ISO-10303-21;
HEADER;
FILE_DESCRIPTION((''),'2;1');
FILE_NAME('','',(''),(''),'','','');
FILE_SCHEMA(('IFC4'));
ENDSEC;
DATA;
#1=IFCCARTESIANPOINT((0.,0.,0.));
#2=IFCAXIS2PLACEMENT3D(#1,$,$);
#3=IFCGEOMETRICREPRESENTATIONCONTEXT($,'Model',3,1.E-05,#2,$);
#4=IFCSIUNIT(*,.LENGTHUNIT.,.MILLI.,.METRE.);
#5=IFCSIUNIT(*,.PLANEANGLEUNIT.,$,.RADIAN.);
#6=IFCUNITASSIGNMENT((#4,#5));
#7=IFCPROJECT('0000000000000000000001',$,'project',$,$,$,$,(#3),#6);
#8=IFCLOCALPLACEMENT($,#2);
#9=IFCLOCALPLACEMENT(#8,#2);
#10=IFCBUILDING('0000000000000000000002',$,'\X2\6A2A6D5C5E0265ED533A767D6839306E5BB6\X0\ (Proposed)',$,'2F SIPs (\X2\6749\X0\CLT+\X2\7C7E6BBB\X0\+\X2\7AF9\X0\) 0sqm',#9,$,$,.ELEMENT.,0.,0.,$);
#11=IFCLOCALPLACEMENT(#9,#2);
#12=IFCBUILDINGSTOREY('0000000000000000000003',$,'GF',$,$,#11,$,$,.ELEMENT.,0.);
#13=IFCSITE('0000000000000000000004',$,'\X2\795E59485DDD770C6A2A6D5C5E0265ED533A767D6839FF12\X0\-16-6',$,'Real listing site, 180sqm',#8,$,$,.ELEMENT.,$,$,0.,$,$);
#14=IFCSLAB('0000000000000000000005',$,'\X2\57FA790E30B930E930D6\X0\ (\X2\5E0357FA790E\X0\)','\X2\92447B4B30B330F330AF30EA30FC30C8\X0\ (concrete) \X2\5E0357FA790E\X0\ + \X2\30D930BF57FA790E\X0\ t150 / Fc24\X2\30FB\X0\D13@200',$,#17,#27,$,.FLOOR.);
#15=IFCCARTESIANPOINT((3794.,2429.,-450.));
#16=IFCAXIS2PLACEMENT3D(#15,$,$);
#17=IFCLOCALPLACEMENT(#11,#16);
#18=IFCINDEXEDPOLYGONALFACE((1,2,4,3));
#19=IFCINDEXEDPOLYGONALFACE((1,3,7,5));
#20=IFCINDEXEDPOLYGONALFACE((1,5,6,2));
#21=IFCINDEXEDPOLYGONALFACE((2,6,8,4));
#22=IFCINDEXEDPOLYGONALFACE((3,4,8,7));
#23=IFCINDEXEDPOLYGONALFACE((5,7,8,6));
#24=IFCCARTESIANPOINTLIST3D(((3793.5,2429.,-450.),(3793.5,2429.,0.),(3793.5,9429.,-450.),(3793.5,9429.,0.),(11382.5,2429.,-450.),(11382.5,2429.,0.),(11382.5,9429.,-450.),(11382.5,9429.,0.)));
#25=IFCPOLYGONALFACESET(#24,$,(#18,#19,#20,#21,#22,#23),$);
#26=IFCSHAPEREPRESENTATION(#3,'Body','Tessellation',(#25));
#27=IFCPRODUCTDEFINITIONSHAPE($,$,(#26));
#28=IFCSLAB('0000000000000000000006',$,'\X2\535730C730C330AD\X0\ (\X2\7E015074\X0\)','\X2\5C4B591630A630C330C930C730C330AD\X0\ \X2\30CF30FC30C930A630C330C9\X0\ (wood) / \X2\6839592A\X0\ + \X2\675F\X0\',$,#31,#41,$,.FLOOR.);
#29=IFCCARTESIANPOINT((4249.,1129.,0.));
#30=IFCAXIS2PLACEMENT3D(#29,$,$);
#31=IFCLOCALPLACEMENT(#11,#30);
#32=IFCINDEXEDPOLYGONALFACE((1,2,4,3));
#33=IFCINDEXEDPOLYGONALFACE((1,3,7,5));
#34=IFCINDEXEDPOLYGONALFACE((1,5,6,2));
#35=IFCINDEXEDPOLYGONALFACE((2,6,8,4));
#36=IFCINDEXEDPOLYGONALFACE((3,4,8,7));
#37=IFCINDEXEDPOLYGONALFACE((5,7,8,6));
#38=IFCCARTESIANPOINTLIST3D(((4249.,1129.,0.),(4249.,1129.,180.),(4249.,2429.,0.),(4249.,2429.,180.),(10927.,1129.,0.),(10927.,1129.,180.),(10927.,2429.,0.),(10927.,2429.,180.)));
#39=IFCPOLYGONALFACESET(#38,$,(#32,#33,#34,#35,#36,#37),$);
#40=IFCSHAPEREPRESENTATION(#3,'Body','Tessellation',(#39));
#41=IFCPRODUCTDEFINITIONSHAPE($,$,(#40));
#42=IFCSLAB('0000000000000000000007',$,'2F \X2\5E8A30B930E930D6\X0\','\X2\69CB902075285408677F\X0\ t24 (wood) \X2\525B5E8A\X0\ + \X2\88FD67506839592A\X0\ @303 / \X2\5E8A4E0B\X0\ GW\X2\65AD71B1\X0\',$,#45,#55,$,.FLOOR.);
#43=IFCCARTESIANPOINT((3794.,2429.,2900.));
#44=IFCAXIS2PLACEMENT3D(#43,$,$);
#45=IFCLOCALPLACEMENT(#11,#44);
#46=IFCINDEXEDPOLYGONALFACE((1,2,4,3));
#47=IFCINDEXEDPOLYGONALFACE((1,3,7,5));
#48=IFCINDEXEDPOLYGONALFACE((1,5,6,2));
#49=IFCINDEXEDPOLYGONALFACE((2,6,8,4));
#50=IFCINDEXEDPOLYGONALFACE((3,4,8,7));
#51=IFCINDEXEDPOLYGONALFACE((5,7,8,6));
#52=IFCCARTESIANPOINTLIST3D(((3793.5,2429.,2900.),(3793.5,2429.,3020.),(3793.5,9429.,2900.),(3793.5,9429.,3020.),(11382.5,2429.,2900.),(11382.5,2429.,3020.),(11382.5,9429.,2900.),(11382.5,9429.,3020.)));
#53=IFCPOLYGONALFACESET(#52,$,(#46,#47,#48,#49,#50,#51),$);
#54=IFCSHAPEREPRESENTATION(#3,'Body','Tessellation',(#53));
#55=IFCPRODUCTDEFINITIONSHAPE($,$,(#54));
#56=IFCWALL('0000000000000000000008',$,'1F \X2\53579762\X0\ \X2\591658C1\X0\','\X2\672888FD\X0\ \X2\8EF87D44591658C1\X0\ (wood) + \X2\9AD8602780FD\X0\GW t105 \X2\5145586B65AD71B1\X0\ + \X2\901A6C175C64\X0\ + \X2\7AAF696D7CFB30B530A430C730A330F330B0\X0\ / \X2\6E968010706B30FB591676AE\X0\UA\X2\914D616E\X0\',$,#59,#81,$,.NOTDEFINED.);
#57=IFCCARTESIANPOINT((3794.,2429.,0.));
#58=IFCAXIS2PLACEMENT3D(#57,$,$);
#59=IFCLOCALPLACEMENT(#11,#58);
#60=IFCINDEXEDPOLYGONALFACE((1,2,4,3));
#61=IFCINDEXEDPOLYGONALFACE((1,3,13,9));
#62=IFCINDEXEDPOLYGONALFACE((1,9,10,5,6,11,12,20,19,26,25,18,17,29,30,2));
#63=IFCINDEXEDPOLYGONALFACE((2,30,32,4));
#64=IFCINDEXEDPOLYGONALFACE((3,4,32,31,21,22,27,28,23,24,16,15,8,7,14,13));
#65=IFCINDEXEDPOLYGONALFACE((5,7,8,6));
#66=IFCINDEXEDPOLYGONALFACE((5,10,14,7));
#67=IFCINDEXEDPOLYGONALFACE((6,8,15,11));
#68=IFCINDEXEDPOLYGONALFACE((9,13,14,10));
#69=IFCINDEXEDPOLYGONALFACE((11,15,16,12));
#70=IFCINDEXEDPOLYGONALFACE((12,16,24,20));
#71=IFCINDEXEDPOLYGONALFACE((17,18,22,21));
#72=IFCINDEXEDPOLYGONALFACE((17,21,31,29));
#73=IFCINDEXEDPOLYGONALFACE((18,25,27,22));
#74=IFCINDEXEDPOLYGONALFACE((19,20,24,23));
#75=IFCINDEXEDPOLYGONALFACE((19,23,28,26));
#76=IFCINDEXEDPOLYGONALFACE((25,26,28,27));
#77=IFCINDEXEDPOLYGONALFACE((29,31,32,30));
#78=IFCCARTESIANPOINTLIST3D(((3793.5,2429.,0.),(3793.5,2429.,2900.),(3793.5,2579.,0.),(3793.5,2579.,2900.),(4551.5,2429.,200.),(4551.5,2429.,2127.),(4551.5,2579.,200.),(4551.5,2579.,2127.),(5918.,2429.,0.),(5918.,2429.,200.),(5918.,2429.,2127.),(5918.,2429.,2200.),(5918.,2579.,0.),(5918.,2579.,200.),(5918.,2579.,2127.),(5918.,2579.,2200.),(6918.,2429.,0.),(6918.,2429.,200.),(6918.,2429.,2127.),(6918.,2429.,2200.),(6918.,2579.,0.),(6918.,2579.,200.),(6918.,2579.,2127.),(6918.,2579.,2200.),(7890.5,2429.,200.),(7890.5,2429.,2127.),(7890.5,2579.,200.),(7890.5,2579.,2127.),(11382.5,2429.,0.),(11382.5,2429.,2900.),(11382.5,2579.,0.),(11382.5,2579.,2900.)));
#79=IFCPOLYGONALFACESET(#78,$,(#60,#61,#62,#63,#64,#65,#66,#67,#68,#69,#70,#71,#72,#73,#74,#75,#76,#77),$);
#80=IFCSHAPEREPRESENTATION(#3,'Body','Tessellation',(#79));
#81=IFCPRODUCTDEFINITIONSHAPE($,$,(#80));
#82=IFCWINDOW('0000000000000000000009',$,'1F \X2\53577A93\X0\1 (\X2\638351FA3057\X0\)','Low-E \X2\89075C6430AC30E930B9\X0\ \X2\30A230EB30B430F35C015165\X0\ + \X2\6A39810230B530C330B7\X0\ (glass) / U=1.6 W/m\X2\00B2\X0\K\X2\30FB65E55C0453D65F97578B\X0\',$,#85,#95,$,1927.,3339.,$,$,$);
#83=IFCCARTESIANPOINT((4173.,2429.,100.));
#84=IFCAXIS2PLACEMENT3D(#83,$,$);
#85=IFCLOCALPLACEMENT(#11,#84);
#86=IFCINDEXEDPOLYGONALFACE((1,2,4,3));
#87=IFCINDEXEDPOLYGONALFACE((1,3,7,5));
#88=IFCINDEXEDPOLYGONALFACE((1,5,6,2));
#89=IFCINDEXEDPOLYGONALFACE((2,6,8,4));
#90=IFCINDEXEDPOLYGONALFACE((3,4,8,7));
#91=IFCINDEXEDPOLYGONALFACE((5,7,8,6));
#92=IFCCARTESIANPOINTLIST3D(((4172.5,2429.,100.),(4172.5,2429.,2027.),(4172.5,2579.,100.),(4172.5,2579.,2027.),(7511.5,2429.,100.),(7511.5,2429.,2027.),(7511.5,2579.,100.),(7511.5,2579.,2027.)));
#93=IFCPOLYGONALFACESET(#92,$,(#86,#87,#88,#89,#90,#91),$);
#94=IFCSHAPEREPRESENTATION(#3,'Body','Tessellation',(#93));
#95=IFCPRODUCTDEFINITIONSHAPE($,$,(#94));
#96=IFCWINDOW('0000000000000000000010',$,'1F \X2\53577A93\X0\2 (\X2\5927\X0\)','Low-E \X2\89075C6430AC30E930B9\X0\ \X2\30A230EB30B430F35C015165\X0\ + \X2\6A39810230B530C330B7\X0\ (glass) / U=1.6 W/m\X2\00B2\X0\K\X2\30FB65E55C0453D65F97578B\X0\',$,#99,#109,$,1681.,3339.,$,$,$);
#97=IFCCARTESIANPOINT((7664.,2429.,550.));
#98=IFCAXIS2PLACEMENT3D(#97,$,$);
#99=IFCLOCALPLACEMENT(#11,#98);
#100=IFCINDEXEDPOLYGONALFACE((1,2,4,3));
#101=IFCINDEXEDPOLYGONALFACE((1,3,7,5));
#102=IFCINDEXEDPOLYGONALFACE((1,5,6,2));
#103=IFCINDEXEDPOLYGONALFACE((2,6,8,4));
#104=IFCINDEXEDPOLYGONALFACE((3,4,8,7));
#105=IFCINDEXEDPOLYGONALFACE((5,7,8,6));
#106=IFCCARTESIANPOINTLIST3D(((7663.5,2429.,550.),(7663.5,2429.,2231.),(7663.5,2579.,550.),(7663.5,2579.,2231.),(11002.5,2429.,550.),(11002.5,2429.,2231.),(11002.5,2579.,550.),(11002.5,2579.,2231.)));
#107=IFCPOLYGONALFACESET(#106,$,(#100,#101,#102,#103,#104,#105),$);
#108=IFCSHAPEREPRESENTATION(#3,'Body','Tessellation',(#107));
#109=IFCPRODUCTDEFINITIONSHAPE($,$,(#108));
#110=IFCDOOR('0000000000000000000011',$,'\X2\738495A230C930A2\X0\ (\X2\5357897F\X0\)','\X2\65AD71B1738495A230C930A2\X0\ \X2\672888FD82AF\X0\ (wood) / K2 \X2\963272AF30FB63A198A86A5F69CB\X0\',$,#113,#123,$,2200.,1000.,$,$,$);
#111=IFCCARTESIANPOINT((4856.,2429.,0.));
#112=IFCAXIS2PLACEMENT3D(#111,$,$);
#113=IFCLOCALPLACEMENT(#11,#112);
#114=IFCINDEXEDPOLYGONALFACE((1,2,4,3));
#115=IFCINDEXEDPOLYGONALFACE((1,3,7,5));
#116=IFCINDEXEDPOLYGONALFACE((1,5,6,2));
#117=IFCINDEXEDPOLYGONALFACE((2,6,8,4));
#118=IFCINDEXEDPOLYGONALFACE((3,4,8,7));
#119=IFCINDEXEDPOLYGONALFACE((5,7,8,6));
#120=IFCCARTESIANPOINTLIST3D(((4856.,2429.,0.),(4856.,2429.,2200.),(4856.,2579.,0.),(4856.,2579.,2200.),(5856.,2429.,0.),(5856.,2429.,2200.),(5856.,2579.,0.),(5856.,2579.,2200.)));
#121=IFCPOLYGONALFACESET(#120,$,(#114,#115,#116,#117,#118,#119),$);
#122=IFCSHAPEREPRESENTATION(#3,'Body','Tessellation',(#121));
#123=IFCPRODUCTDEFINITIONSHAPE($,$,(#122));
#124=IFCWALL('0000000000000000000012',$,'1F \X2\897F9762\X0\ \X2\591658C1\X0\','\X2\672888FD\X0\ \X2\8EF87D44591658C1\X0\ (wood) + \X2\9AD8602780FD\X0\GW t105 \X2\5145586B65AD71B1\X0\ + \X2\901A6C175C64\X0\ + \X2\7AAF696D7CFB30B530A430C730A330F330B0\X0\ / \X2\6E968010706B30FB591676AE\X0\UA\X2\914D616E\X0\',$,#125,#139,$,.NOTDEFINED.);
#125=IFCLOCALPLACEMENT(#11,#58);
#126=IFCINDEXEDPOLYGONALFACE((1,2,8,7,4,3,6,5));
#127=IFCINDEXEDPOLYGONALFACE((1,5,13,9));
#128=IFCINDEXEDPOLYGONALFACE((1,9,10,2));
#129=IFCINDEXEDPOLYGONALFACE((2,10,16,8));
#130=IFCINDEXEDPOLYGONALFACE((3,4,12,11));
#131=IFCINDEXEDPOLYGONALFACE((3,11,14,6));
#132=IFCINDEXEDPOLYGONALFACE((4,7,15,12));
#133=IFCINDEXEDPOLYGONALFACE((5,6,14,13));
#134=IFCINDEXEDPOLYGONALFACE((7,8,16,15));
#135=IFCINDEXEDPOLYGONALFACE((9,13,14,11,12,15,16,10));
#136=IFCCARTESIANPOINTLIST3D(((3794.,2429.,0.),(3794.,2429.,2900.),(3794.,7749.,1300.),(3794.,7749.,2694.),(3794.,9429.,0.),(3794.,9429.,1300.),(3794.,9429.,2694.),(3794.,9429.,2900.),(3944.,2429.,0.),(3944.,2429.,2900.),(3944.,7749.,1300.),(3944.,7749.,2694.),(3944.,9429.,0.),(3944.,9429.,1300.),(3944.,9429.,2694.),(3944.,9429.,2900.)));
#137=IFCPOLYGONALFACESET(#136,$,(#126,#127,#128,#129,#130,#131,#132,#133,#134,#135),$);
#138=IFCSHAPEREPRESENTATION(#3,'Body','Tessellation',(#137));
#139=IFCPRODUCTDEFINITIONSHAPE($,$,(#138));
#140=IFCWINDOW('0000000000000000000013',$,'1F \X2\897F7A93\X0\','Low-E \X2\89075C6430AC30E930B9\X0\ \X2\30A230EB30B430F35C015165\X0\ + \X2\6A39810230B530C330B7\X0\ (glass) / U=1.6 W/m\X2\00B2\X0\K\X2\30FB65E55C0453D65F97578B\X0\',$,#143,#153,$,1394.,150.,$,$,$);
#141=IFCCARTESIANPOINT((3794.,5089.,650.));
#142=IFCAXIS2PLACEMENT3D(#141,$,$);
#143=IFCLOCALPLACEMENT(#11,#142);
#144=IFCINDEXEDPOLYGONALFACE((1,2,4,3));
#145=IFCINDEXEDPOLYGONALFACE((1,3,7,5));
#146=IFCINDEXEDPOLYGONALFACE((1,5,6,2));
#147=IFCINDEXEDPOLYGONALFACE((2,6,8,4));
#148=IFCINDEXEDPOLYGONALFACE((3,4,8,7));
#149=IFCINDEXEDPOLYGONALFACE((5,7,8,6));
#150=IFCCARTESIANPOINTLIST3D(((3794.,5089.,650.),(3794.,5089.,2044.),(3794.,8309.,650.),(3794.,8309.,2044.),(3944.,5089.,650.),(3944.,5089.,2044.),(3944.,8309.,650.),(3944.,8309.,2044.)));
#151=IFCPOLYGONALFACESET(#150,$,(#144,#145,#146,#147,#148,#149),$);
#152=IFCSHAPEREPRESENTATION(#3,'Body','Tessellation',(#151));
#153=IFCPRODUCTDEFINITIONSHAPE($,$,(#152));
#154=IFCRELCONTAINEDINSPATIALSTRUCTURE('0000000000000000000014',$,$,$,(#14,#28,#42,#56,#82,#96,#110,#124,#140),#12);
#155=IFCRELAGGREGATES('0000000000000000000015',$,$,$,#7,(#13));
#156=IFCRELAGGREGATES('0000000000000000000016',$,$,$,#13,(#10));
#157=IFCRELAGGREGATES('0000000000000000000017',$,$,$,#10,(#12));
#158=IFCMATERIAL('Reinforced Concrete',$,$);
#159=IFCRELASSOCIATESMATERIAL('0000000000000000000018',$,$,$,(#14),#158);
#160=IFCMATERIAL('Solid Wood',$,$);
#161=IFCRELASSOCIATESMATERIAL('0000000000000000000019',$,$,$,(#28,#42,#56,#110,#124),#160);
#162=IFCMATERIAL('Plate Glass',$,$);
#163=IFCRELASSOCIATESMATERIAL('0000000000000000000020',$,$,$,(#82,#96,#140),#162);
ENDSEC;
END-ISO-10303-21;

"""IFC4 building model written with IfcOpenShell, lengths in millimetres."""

from ifc_helpers import new_model, si_unit, frame, frame_2d, origin, place, context, project, spatial, rectangle, extrude, material, element, fill, save


model = new_model("IFC4")

# Units and contexts
model_context = context("Model", 3, precision=1e-05, world=origin())
ifc_project = project(units=[si_unit("LENGTHUNIT", "METRE", prefix="MILLI"), si_unit("PLANEANGLEUNIT", "RADIAN")], contexts=[model_context])

# Site, building, storey
site_placement = place(None, origin())
site = spatial("IfcSite", under=ifc_project, at=site_placement, Name="神奈川県横浜市旭区白根２-16-6", ObjectType="Real listing site, 180sqm", CompositionType="ELEMENT", RefElevation=0.0)
building_placement = place(site_placement, origin())
building = spatial("IfcBuilding", under=site, at=building_placement, Name="横浜市旭区白根の家 (Proposed)", ObjectType="2F SIPs (杉CLT+籾殻+竹) 0sqm", CompositionType="ELEMENT", ElevationOfRefHeight=0.0, ElevationOfTerrain=0.0)
storey_placement = place(building_placement, origin())
storey = spatial("IfcBuildingStorey", under=building, at=storey_placement, Name="GF", CompositionType="ELEMENT", Elevation=0.0)

# Slabs
ifc_material_1 = material(Name="Reinforced Concrete")
slab_1_placement = place(storey_placement, frame((3794.0, 2429.0, -450.0)))
element("IfcSlab", 1, at=slab_1_placement, inside=storey, material=ifc_material_1, Name="基礎スラブ (布基礎)", Description="鉄筋コンクリート (concrete) 布基礎 + ベタ基礎 t150 / Fc24・D13@200", PredefinedType="FLOOR", context=model_context, shape_type="SweptSolid", body=[
    extrude(rectangle(XDim=7589.0, YDim=7000.0, at=frame_2d((3794.0, 3500.0))), frame((3794.0, 2429.0, -450.0)), (0.0, 0.0, 1.0), 450.0),
])
ifc_material_2 = material(Name="Solid Wood")
slab_2_placement = place(storey_placement, frame((4249.0, 1129.0, 0.0)))
element("IfcSlab", 2, at=slab_2_placement, inside=storey, material=ifc_material_2, Name="南デッキ (縁側)", Description="屋外ウッドデッキ ハードウッド (wood) / 根太 + 束", PredefinedType="FLOOR", context=model_context, shape_type="SweptSolid", body=[
    extrude(rectangle(XDim=6678.0, YDim=1300.0, at=frame_2d((3339.0, 650.0))), frame((4249.0, 1129.0, 0.0)), (0.0, 0.0, 1.0), 180.0),
])
slab_3_placement = place(storey_placement, frame((3794.0, 2429.0, 2900.0)))
element("IfcSlab", 3, at=slab_3_placement, inside=storey, material=ifc_material_2, Name="2F 床スラブ", Description="構造用合板 t24 (wood) 剛床 + 製材根太 @303 / 床下 GW断熱", PredefinedType="FLOOR", context=model_context, shape_type="SweptSolid", body=[
    extrude(rectangle(XDim=7589.0, YDim=7000.0, at=frame_2d((3794.0, 3500.0))), frame((3794.0, 2429.0, 2900.0)), (0.0, 0.0, 1.0), 120.0),
])

# Wall, openings, windows, door
wall_1_placement = place(storey_placement, frame((3794.0, 2429.0, 0.0)))
wall_1 = element("IfcWall", 4, at=wall_1_placement, inside=storey, material=ifc_material_2, Name="1F 南面 外壁", Description="木製 軸組外壁 (wood) + 高性能GW t105 充填断熱 + 通気層 + 窯業系サイディング / 準耐火・外皮UA配慮", PredefinedType="NOTDEFINED", context=model_context, shape_type="SweptSolid", body=[
    extrude(rectangle(XDim=7589.0, YDim=150.0, at=frame_2d((3794.0, 75.0))), frame((3794.0, 2429.0, 0.0)), (0.0, 0.0, 1.0), 2900.0),
])
opening_1_placement = place(storey_placement, frame((4173.0, 2429.0, 100.0)))
opening_1 = element("IfcOpeningElement", 5, at=opening_1_placement, cuts=wall_1, PredefinedType="NOTDEFINED", context=model_context, shape_type="SweptSolid", body=[
    extrude(rectangle(XDim=3339.0, YDim=150.0, at=frame_2d((1669.0, 75.0))), frame((4173.0, 2429.0, 100.0)), (0.0, 0.0, 1.0), 1927.0),
])
opening_2_placement = place(storey_placement, frame((7664.0, 2429.0, 550.0)))
opening_2 = element("IfcOpeningElement", 6, at=opening_2_placement, cuts=wall_1, PredefinedType="NOTDEFINED", context=model_context, shape_type="SweptSolid", body=[
    extrude(rectangle(XDim=3339.0, YDim=150.0, at=frame_2d((1669.0, 75.0))), frame((7664.0, 2429.0, 550.0)), (0.0, 0.0, 1.0), 1681.0),
])
opening_3_placement = place(storey_placement, frame((4856.0, 2429.0, 0.0)))
opening_3 = element("IfcOpeningElement", 7, at=opening_3_placement, cuts=wall_1, PredefinedType="NOTDEFINED", context=model_context, shape_type="SweptSolid", body=[
    extrude(rectangle(XDim=1000.0, YDim=150.0, at=frame_2d((500.0, 75.0))), frame((4856.0, 2429.0, 0.0)), (0.0, 0.0, 1.0), 2200.0),
])
ifc_material_3 = material(Name="Plate Glass")
window_1_placement = place(storey_placement, frame((4173.0, 2429.0, 100.0)))
window_1 = element("IfcWindow", 8, at=window_1_placement, inside=storey, material=ifc_material_3, Name="1F 南窓1 (掃出し)", Description="Low-E 複層ガラス アルゴン封入 + 樹脂サッシ (glass) / U=1.6 W/m²K・日射取得型", OverallHeight=1927.0, OverallWidth=3339.0, context=model_context, shape_type="SweptSolid", body=[
    extrude(rectangle(XDim=3339.0, YDim=150.0, at=frame_2d((1669.0, 75.0))), frame((4173.0, 2429.0, 100.0)), (0.0, 0.0, 1.0), 1927.0),
])
fill(opening_1, window_1)
window_2_placement = place(storey_placement, frame((7664.0, 2429.0, 550.0)))
window_2 = element("IfcWindow", 9, at=window_2_placement, inside=storey, material=ifc_material_3, Name="1F 南窓2 (大)", Description="Low-E 複層ガラス アルゴン封入 + 樹脂サッシ (glass) / U=1.6 W/m²K・日射取得型", OverallHeight=1681.0, OverallWidth=3339.0, context=model_context, shape_type="SweptSolid", body=[
    extrude(rectangle(XDim=3339.0, YDim=150.0, at=frame_2d((1669.0, 75.0))), frame((7664.0, 2429.0, 550.0)), (0.0, 0.0, 1.0), 1681.0),
])
fill(opening_2, window_2)
door_placement = place(storey_placement, frame((4856.0, 2429.0, 0.0)))
door = element("IfcDoor", 10, at=door_placement, inside=storey, material=ifc_material_2, Name="玄関ドア (南西)", Description="断熱玄関ドア 木製芯 (wood) / K2 防犯・採風機構", OverallHeight=2200.0, OverallWidth=1000.0, context=model_context, shape_type="SweptSolid", body=[
    extrude(rectangle(XDim=1000.0, YDim=150.0, at=frame_2d((500.0, 75.0))), frame((4856.0, 2429.0, 0.0)), (0.0, 0.0, 1.0), 2200.0),
])
fill(opening_3, door)

# Wall, opening, window
wall_2_placement = place(storey_placement, frame((3794.0, 2429.0, 0.0)))
wall_2 = element("IfcWall", 11, at=wall_2_placement, inside=storey, material=ifc_material_2, Name="1F 西面 外壁", Description="木製 軸組外壁 (wood) + 高性能GW t105 充填断熱 + 通気層 + 窯業系サイディング / 準耐火・外皮UA配慮", PredefinedType="NOTDEFINED", context=model_context, shape_type="SweptSolid", body=[
    extrude(rectangle(XDim=150.0, YDim=7000.0, at=frame_2d((75.0, 3500.0))), frame((3794.0, 2429.0, 0.0)), (0.0, 0.0, 1.0), 2900.0),
])
opening_4_placement = place(storey_placement, frame((3794.0, 5089.0, 650.0)))
opening_4 = element("IfcOpeningElement", 12, at=opening_4_placement, cuts=wall_2, PredefinedType="NOTDEFINED", context=model_context, shape_type="SweptSolid", body=[
    extrude(rectangle(XDim=150.0, YDim=3220.0, at=frame_2d((75.0, 1610.0))), frame((3794.0, 5089.0, 650.0)), (0.0, 0.0, 1.0), 1394.0),
])
window_3_placement = place(storey_placement, frame((3794.0, 5089.0, 650.0)))
window_3 = element("IfcWindow", 13, at=window_3_placement, inside=storey, material=ifc_material_3, Name="1F 西窓", Description="Low-E 複層ガラス アルゴン封入 + 樹脂サッシ (glass) / U=1.6 W/m²K・日射取得型", OverallHeight=1394.0, OverallWidth=150.0, context=model_context, shape_type="SweptSolid", body=[
    extrude(rectangle(XDim=150.0, YDim=3220.0, at=frame_2d((75.0, 1610.0))), frame((3794.0, 5089.0, 650.0)), (0.0, 0.0, 1.0), 1394.0),
])
fill(opening_4, window_3)

save(model, "model.ifc")
